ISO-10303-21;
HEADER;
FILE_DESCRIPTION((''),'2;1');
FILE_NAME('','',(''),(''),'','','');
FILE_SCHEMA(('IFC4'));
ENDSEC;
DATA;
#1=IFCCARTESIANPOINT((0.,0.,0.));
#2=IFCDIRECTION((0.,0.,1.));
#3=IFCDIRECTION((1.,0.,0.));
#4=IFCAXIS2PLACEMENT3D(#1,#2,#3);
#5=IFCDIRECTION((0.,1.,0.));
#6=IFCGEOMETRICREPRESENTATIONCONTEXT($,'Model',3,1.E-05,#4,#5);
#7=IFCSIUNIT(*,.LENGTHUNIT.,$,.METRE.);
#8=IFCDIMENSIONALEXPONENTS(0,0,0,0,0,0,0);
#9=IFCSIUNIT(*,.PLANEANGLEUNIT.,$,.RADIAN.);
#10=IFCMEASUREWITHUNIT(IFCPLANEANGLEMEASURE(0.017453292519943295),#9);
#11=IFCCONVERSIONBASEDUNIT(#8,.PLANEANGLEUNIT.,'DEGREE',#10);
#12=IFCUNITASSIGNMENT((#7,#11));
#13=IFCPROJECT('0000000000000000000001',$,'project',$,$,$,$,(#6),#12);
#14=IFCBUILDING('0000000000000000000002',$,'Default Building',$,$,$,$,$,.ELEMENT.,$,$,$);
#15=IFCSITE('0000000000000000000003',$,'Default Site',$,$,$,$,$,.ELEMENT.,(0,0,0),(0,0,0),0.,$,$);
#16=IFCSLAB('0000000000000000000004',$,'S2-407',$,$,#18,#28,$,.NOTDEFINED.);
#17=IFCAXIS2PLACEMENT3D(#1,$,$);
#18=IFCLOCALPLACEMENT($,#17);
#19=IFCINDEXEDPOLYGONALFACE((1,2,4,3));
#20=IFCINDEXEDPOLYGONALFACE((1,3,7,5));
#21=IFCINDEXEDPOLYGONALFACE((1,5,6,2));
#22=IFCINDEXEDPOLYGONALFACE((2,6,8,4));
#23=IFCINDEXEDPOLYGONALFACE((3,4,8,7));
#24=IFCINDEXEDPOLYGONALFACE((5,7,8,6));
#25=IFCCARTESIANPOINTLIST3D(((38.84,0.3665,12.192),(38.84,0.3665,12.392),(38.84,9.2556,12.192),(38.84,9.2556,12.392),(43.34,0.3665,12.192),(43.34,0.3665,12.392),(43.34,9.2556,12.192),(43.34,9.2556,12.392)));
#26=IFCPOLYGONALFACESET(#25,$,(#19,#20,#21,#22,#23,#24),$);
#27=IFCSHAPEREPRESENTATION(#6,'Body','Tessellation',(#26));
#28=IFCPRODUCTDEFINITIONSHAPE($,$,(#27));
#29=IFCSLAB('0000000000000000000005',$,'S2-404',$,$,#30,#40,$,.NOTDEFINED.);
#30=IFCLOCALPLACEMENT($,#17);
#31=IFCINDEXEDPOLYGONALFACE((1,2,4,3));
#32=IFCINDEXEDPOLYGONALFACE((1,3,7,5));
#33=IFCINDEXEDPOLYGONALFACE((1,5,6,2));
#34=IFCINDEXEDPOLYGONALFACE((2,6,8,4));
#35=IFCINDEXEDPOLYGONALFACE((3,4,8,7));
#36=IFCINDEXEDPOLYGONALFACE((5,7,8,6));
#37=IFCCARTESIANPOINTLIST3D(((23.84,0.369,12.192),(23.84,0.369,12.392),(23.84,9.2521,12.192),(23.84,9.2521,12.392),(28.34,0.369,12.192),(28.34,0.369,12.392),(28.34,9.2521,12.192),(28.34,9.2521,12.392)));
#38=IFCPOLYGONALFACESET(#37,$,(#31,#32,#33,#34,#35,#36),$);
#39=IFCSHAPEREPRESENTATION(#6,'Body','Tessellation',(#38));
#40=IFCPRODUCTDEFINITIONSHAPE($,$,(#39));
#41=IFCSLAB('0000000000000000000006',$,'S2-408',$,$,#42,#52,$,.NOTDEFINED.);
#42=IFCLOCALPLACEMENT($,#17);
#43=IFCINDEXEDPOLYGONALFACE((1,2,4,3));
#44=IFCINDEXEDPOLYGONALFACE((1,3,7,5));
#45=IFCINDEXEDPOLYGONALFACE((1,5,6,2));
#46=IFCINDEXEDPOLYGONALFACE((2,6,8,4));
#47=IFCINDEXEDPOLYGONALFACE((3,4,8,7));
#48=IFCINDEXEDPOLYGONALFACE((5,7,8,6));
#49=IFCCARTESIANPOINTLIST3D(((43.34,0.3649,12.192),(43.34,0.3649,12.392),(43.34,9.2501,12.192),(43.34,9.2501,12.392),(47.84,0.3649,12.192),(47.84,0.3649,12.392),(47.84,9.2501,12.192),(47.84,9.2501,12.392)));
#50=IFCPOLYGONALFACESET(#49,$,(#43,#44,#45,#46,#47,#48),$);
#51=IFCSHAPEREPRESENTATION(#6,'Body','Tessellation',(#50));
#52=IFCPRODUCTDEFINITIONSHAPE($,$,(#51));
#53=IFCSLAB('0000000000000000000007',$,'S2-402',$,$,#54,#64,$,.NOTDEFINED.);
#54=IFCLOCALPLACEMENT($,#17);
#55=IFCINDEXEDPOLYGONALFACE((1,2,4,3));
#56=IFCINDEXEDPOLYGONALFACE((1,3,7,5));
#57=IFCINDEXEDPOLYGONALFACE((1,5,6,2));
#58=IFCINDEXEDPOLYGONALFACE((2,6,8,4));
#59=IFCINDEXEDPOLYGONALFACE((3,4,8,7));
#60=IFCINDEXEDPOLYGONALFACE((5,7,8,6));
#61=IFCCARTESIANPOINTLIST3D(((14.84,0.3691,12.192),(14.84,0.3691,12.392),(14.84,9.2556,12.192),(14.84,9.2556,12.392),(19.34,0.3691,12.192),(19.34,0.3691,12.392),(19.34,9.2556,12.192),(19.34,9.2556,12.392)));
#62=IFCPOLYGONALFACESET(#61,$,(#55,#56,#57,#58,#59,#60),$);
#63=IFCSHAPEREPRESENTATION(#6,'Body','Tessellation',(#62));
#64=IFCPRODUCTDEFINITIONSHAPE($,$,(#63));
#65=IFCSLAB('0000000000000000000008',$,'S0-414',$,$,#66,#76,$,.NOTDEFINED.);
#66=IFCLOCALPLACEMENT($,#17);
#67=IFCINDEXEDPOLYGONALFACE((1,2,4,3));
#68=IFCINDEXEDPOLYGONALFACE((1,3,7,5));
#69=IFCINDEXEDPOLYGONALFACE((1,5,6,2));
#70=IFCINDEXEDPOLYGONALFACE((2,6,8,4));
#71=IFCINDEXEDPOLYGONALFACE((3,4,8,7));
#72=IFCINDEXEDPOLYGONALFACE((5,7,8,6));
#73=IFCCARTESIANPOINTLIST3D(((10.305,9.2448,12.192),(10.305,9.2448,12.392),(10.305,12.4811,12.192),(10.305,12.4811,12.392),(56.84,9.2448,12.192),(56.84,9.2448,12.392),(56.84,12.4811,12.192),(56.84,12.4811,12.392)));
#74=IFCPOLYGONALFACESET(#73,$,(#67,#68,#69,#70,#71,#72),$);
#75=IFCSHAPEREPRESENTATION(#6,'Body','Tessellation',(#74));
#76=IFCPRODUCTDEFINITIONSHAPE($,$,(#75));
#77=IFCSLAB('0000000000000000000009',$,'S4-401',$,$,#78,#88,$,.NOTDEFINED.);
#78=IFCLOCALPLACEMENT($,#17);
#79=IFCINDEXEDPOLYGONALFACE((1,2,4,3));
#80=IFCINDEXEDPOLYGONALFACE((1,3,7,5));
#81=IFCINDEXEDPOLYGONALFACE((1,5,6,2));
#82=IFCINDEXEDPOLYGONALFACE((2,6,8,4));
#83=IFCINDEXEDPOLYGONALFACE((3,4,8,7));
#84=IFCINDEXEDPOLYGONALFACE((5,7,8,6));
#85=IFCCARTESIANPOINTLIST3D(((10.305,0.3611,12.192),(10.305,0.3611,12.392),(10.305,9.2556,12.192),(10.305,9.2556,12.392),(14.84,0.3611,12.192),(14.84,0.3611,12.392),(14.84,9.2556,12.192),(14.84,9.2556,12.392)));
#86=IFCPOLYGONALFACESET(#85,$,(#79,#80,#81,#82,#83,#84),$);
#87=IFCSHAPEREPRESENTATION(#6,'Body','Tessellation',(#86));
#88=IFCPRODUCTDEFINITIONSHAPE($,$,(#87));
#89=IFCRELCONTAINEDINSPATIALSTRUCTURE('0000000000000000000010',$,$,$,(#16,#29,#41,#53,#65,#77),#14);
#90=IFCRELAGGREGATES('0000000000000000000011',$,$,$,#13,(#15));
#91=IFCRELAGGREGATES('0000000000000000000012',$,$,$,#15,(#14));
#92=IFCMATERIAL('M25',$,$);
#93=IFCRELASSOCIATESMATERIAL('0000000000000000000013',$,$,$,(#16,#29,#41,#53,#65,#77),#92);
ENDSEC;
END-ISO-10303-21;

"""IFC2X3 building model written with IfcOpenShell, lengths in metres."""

from ifc_helpers import new_model, entity, si_unit, converted_unit, direction, frame, frame_2d, origin_with_axes, place, context, project, spatial, rectangle, extrude, material, element, save


model = new_model("IFC2X3")

# Units and contexts
model_context = context("Model", 3, precision=1e-05, world=origin_with_axes(), true_north=direction((0.0, 1.0, 0.0)))
ifc_project = project(units=[si_unit("LENGTHUNIT", "METRE"), converted_unit("PLANEANGLEUNIT", "DEGREE", entity("IfcPlaneAngleMeasure", 0.017453292519943295), si_unit("PLANEANGLEUNIT", "RADIAN"), dimensions=[0, 0, 0, 0, 0, 0, 0])], contexts=[model_context])

# Site, building
site = spatial("IfcSite", under=ifc_project, Name="Default Site", CompositionType="ELEMENT", RefLatitude=(0, 0, 0), RefLongitude=(0, 0, 0), RefElevation=0.0)
building = spatial("IfcBuilding", under=site, Name="Default Building", CompositionType="ELEMENT")

# Shared definitions
ifc_material = material(Name="M25")
placement = place(None, origin_with_axes())

# Slabs
element("IfcSlab", 1, at=placement, inside=building, material=ifc_material, Name="S2-407", PredefinedType="NOTDEFINED", context=model_context, shape_type="SweptSolid", body=[
    extrude(rectangle(XDim=4.5, YDim=8.8891, at=frame_2d((0.0, 0.0), x_axis=(1.0, 0.0, 0.0))), frame((41.09, 4.811, 12.192), z_axis=(0.0, 0.0, 1.0), x_axis=(1.0, 0.0, 0.0)), (0.0, 0.0, 1.0), 0.2),
])
element("IfcSlab", 2, at=placement, inside=building, material=ifc_material, Name="S2-404", PredefinedType="NOTDEFINED", context=model_context, shape_type="SweptSolid", body=[
    extrude(rectangle(XDim=4.5, YDim=8.8831, at=frame_2d((0.0, 0.0), x_axis=(1.0, 0.0, 0.0))), frame((26.09, 4.8106, 12.192), z_axis=(0.0, 0.0, 1.0), x_axis=(1.0, 0.0, 0.0)), (0.0, 0.0, 1.0), 0.2),
])
element("IfcSlab", 3, at=placement, inside=building, material=ifc_material, Name="S2-408", PredefinedType="NOTDEFINED", context=model_context, shape_type="SweptSolid", body=[
    extrude(rectangle(XDim=4.5, YDim=8.8852, at=frame_2d((0.0, 0.0), x_axis=(1.0, 0.0, 0.0))), frame((45.59, 4.8075, 12.192), z_axis=(0.0, 0.0, 1.0), x_axis=(1.0, 0.0, 0.0)), (0.0, 0.0, 1.0), 0.2),
])
element("IfcSlab", 4, at=placement, inside=building, material=ifc_material, Name="S2-402", PredefinedType="NOTDEFINED", context=model_context, shape_type="SweptSolid", body=[
    extrude(rectangle(XDim=4.5, YDim=8.8865, at=frame_2d((0.0, 0.0), x_axis=(1.0, 0.0, 0.0))), frame((17.09, 4.8123, 12.192), z_axis=(0.0, 0.0, 1.0), x_axis=(1.0, 0.0, 0.0)), (0.0, 0.0, 1.0), 0.2),
])
element("IfcSlab", 5, at=placement, inside=building, material=ifc_material, Name="S0-414", PredefinedType="NOTDEFINED", context=model_context, shape_type="SweptSolid", body=[
    extrude(rectangle(XDim=46.535, YDim=3.2363, at=frame_2d((0.0, 0.0), x_axis=(1.0, 0.0, 0.0))), frame((33.5725, 10.863, 12.192), z_axis=(0.0, 0.0, 1.0), x_axis=(1.0, 0.0, 0.0)), (0.0, 0.0, 1.0), 0.2),
])
element("IfcSlab", 6, at=placement, inside=building, material=ifc_material, Name="S4-401", PredefinedType="NOTDEFINED", context=model_context, shape_type="SweptSolid", body=[
    extrude(rectangle(XDim=4.535, YDim=8.8945, at=frame_2d((0.0, 0.0), x_axis=(1.0, 0.0, 0.0))), frame((12.5725, 4.8083, 12.192), z_axis=(0.0, 0.0, 1.0), x_axis=(1.0, 0.0, 0.0)), (0.0, 0.0, 1.0), 0.2),
])

save(model, "model.ifc")
